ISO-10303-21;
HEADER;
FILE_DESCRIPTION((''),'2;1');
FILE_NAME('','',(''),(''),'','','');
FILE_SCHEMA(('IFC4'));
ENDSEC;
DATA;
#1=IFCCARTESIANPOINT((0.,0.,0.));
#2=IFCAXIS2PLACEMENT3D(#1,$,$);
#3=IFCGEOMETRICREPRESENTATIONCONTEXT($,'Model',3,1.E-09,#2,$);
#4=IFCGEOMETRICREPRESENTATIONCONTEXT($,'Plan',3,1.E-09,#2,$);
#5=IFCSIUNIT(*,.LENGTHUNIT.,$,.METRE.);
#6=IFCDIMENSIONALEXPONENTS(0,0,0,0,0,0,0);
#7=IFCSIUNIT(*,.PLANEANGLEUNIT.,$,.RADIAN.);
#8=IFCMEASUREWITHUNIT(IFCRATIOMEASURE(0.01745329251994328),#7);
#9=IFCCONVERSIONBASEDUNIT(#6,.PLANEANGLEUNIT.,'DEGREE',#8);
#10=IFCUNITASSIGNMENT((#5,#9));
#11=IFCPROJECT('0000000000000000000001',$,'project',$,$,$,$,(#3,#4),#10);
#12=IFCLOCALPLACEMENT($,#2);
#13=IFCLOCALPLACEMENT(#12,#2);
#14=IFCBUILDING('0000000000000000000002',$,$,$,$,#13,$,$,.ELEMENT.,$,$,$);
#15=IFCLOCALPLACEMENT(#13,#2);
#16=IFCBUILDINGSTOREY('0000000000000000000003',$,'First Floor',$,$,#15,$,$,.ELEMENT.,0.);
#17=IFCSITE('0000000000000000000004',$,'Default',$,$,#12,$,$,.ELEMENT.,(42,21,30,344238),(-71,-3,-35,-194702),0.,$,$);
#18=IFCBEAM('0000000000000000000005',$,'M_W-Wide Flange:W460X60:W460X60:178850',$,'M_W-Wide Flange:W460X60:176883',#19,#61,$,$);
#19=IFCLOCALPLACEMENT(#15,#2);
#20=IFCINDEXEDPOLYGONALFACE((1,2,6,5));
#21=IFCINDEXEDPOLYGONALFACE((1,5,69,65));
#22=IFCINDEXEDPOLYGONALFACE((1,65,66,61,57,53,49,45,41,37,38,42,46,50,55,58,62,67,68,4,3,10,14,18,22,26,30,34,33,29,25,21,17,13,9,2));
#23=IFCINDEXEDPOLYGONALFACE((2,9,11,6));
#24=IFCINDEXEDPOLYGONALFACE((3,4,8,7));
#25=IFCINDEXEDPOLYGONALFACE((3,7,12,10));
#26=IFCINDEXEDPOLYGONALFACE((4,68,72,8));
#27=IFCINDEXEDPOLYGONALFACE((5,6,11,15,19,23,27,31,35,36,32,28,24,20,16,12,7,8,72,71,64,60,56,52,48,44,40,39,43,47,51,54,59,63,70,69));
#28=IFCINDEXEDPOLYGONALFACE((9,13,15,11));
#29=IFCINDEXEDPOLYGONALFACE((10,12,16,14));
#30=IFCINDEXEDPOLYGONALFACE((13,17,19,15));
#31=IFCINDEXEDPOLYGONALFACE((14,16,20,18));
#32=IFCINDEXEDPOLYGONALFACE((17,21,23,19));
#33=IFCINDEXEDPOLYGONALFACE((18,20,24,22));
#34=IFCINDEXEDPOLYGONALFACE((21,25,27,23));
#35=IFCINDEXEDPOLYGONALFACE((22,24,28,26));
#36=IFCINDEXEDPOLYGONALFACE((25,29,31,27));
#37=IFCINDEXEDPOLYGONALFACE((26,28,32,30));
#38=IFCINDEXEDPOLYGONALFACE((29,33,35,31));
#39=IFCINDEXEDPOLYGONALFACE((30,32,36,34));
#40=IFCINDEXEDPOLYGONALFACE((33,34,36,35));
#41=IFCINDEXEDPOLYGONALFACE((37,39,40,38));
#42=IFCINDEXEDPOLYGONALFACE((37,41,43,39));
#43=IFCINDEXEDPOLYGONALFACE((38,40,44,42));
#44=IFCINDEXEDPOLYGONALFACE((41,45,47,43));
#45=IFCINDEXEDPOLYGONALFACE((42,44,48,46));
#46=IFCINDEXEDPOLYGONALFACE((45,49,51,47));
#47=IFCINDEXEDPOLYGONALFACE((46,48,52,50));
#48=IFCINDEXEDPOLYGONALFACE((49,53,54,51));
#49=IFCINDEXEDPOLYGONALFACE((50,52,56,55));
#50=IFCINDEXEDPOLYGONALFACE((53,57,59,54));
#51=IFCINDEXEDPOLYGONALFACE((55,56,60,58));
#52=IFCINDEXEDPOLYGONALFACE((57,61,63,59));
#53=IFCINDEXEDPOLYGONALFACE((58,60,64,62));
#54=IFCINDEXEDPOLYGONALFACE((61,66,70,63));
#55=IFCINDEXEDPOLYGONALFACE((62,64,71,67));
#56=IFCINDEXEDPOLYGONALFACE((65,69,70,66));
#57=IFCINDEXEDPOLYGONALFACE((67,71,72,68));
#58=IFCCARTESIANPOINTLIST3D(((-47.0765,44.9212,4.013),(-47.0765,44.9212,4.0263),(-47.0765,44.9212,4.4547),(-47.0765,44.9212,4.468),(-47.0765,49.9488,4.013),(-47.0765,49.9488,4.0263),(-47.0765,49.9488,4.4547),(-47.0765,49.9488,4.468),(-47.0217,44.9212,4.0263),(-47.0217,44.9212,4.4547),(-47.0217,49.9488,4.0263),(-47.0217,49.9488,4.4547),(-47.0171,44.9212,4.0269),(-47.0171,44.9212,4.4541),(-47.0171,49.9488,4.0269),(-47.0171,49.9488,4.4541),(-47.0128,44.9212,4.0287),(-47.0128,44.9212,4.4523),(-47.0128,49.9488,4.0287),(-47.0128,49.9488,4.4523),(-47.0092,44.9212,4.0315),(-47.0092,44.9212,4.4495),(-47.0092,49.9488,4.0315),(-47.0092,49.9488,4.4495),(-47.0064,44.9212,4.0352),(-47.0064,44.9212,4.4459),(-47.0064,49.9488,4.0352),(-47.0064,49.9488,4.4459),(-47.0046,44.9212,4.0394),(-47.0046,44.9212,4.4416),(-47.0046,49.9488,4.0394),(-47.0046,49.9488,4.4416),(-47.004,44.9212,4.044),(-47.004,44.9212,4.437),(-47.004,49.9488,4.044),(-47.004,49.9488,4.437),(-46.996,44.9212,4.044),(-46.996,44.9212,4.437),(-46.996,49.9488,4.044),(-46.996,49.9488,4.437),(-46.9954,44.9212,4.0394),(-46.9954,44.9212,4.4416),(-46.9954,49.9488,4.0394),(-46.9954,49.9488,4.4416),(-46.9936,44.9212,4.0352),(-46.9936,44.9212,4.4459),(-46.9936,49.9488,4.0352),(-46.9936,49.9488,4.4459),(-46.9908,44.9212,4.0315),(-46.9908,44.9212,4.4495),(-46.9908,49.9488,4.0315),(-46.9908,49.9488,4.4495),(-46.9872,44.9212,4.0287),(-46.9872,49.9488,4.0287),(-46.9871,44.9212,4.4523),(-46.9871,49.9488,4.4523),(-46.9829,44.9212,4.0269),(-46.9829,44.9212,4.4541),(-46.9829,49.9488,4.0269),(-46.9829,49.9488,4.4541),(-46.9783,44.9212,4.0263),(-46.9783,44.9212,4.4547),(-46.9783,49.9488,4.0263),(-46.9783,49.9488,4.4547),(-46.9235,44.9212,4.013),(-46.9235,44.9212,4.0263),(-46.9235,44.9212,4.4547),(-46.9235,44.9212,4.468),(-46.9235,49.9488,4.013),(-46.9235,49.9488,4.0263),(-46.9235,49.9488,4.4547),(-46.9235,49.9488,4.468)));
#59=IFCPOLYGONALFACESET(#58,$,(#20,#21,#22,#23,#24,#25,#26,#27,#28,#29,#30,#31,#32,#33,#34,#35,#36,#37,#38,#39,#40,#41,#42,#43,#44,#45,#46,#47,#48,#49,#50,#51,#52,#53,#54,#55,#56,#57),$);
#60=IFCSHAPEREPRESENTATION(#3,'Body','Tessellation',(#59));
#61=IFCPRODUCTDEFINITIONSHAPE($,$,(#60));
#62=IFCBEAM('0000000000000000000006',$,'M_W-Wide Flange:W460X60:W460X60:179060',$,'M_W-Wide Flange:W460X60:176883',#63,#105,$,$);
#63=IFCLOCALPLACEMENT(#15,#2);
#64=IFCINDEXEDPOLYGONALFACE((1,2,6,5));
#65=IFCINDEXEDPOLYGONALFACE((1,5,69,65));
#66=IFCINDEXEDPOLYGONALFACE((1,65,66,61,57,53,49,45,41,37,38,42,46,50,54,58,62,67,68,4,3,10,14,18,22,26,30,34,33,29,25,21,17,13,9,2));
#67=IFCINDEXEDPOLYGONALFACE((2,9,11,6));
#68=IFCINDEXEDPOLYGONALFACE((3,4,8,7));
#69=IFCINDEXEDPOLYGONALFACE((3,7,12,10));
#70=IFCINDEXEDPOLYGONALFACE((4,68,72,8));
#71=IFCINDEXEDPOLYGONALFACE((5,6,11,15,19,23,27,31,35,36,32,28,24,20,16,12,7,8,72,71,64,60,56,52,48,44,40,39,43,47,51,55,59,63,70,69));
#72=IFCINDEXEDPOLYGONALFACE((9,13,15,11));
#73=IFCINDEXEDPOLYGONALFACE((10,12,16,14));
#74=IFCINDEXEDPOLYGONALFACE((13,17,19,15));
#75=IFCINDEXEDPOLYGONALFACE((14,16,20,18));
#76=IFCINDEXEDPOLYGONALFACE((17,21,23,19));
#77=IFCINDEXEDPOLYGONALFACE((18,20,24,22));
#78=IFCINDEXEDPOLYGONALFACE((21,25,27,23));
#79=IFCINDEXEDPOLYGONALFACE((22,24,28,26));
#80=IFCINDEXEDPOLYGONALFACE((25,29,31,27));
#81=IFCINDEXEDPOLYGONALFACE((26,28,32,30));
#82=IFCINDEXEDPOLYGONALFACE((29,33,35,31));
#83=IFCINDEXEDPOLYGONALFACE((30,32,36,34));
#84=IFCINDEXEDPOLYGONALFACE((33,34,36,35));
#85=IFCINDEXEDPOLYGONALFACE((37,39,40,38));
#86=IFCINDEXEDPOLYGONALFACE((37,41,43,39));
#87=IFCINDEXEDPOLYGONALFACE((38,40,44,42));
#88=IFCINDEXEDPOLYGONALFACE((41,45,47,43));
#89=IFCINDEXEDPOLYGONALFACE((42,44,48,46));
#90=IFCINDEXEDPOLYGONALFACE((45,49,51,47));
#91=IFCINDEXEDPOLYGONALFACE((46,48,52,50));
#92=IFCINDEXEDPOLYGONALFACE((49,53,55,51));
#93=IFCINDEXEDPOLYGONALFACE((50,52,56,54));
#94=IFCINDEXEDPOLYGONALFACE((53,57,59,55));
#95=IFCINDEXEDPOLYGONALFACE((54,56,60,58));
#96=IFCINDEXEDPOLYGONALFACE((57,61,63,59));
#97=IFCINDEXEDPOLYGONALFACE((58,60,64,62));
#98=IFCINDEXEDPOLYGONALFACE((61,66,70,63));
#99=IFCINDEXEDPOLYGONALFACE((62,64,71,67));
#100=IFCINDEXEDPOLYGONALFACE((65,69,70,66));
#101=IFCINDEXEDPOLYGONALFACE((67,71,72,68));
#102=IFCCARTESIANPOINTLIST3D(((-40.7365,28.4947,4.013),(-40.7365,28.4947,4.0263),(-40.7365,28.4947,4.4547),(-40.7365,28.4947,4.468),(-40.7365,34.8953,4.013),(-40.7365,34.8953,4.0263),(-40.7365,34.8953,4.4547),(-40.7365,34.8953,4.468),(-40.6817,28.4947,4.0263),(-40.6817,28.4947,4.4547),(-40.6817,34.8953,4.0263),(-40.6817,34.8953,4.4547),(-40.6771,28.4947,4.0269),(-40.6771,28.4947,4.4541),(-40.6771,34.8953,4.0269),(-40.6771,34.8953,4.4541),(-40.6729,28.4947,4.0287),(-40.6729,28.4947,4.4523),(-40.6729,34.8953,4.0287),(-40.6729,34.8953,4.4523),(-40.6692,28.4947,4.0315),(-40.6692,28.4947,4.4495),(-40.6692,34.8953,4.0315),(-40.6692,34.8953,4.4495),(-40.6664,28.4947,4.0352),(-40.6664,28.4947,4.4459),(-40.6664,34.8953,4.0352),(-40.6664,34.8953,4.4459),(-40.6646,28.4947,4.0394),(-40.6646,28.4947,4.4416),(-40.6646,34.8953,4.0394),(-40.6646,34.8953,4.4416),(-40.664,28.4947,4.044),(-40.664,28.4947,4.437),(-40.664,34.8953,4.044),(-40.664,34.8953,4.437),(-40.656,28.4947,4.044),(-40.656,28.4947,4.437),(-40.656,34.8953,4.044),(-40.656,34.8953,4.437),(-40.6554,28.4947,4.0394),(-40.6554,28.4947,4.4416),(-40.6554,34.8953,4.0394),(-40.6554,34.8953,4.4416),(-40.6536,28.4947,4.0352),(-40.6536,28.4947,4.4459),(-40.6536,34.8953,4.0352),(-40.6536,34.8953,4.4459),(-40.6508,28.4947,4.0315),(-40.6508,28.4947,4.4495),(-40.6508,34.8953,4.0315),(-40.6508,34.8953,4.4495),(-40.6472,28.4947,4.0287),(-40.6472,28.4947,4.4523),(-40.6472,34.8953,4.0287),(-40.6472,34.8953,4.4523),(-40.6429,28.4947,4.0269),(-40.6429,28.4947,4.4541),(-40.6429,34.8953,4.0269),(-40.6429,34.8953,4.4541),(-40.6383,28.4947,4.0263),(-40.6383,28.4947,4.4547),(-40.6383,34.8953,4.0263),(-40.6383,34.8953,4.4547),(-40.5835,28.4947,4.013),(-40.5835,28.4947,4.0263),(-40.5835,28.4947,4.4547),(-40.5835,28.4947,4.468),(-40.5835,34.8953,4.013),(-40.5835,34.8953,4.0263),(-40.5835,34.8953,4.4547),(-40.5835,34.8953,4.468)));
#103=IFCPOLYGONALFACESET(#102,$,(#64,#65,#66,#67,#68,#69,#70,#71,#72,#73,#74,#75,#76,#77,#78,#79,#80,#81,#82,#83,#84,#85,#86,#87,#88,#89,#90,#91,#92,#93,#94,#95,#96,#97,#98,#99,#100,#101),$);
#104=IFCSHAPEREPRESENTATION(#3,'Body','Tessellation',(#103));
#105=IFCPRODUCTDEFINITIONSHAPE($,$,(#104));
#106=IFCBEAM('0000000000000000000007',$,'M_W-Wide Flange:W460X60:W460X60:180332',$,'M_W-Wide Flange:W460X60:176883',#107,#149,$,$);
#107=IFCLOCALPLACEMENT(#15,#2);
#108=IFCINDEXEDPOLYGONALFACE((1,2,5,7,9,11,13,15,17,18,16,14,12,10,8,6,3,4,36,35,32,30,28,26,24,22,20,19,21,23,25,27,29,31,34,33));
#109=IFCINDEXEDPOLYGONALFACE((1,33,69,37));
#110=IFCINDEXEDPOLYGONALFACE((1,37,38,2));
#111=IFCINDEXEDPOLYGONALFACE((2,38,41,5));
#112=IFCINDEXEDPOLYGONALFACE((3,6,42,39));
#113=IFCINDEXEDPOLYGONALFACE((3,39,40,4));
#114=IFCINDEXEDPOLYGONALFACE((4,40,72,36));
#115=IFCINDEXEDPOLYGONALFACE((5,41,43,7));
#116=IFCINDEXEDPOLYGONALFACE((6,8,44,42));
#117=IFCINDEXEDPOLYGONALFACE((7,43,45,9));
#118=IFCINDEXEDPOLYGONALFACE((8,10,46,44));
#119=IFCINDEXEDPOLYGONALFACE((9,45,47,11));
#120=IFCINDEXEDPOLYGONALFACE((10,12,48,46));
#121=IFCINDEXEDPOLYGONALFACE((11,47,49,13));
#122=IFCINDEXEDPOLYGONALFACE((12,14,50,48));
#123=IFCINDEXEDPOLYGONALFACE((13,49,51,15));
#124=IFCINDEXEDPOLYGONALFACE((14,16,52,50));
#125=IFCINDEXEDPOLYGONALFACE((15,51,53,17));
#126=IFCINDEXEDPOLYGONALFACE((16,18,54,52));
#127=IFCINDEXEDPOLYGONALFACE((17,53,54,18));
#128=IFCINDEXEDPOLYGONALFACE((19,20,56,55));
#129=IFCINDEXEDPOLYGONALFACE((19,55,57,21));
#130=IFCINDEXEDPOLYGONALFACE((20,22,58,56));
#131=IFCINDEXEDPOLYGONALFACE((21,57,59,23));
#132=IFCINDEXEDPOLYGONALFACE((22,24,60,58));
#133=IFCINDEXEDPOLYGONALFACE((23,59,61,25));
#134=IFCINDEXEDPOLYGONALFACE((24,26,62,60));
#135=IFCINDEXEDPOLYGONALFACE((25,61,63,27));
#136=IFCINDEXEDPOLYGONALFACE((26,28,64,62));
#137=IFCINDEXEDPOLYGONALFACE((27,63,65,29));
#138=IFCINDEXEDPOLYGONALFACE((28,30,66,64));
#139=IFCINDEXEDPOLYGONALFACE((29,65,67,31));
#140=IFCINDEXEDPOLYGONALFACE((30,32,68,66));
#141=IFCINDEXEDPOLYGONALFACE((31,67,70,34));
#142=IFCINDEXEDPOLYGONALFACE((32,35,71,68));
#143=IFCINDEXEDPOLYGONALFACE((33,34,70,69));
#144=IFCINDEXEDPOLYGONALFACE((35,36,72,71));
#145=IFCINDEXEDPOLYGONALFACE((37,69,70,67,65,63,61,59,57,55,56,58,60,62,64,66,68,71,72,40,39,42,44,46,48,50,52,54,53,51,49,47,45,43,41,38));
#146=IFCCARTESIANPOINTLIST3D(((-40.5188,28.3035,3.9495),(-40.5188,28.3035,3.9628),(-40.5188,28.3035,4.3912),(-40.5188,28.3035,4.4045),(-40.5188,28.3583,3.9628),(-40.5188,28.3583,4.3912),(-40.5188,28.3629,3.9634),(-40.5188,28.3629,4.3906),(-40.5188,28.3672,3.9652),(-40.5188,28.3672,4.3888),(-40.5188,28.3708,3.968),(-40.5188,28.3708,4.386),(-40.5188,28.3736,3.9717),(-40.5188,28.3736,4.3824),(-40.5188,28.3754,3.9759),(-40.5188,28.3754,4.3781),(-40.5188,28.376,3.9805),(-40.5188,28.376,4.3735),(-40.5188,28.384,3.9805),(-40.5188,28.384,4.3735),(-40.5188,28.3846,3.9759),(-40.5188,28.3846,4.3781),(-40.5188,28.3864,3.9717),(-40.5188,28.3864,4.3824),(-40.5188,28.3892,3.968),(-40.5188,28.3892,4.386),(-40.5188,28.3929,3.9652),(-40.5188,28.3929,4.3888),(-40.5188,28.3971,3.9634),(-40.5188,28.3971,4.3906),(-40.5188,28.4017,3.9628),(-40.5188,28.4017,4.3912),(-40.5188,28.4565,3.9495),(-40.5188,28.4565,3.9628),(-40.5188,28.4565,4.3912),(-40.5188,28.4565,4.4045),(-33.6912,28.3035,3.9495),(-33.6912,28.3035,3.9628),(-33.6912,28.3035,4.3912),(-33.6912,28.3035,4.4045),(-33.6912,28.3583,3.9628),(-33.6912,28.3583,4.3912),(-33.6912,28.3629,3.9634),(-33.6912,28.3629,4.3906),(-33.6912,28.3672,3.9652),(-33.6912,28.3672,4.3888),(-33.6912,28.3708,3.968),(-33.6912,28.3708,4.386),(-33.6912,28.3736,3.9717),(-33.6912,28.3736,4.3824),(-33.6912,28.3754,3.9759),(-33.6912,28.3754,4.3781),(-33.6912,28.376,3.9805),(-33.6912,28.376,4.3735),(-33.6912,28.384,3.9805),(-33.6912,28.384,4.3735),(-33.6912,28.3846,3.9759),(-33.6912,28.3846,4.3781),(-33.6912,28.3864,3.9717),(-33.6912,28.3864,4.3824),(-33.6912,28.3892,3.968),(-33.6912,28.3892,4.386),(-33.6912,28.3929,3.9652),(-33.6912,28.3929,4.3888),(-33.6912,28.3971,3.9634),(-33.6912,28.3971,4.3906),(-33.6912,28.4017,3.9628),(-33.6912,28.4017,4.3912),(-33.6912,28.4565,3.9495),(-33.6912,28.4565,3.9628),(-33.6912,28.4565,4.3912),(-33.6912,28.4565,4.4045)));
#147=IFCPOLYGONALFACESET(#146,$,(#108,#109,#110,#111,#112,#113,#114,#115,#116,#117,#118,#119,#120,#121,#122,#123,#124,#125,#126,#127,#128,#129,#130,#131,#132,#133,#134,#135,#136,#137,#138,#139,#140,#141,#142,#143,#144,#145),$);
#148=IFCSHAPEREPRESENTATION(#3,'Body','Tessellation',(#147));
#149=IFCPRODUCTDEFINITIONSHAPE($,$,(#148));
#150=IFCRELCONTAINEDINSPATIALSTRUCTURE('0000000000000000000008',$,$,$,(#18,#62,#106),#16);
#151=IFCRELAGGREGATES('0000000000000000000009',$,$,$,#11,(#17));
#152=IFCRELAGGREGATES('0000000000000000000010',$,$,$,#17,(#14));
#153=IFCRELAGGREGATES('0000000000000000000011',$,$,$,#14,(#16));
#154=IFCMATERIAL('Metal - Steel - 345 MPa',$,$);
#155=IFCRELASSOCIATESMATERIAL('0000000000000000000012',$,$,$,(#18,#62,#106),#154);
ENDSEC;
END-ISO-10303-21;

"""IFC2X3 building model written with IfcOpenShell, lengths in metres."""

from ifc_helpers import new_model, entity, si_unit, converted_unit, frame, frame_2d, origin, place, context, project, spatial, polyline, circle_curve, parameter, trimmed, segment, composite_curve, outline, extrude, material, element, save


model = new_model("IFC2X3")

# Units and contexts
model_context = context("Model", 3, precision=1e-09, world=origin())
plan_context = context("Plan", 3, precision=1e-09, world=origin())
ifc_project = project(units=[si_unit("LENGTHUNIT", "METRE"), converted_unit("PLANEANGLEUNIT", "DEGREE", entity("IfcRatioMeasure", 0.01745329251994328), si_unit("PLANEANGLEUNIT", "RADIAN"), dimensions=[0, 0, 0, 0, 0, 0, 0])], contexts=[model_context, plan_context])

# Site, building, storey
site_placement = place(None, origin())
site = spatial("IfcSite", under=ifc_project, at=site_placement, Name="Default", CompositionType="ELEMENT", RefLatitude=(42, 21, 30, 344238), RefLongitude=(-71, -3, -35, -194702), RefElevation=0.0)
building_placement = place(site_placement, origin())
building = spatial("IfcBuilding", under=site, at=building_placement, CompositionType="ELEMENT")
storey_placement = place(building_placement, origin())
storey = spatial("IfcBuildingStorey", under=building, at=storey_placement, Name="First Floor", CompositionType="ELEMENT", Elevation=0.0)

# Beams
ifc_material = material(Name="Metal - Steel - 345 MPa")
beam_1_placement = place(storey_placement, frame((-47.0, 44.7774, 4.468)))
element("IfcBeam", 1, at=beam_1_placement, inside=storey, material=ifc_material, Name="M_W-Wide Flange:W460X60:W460X60:178850", ObjectType="M_W-Wide Flange:W460X60:176883", context=model_context, shape_type="SweptSolid", body=[
    extrude(outline(composite_curve([segment(polyline([(-0.0765, -0.2142), (-0.0765, -0.2275)]), True, "CONTINUOUS"), segment(polyline([(-0.0765, -0.2275), (0.0765, -0.2275)]), True, "CONTINUOUS"), segment(polyline([(0.0765, -0.2275), (0.0765, -0.2142)]), True, "CONTINUOUS"), segment(polyline([(0.0765, -0.2142), (0.0217, -0.2142)]), True, "CONTINUOUS"), segment(trimmed(circle_curve(frame_2d((0.0217, -0.1965), x_axis=(0.0, -1.0)), 0.0177), [parameter(270.0)], [parameter(360.0)], True, "PARAMETER"), False, "CONTINUOUS"), segment(polyline([(0.004, -0.1965), (0.004, 0.1965)]), True, "CONTINUOUS"), segment(trimmed(circle_curve(frame_2d((0.0217, 0.1965), x_axis=(-1.0, 0.0)), 0.0177), [parameter(270.0)], [parameter(360.0)], True, "PARAMETER"), False, "CONTINUOUS"), segment(polyline([(0.0217, 0.2142), (0.0765, 0.2142)]), True, "CONTINUOUS"), segment(polyline([(0.0765, 0.2142), (0.0765, 0.2275)]), True, "CONTINUOUS"), segment(polyline([(0.0765, 0.2275), (-0.0765, 0.2275)]), True, "CONTINUOUS"), segment(polyline([(-0.0765, 0.2275), (-0.0765, 0.2142)]), True, "CONTINUOUS"), segment(polyline([(-0.0765, 0.2142), (-0.0217, 0.2142)]), True, "CONTINUOUS"), segment(trimmed(circle_curve(frame_2d((-0.0217, 0.1965), x_axis=(0.0, 1.0)), 0.0177), [parameter(270.0)], [parameter(360.0)], True, "PARAMETER"), False, "CONTINUOUS"), segment(polyline([(-0.004, 0.1965), (-0.004, -0.1965)]), True, "CONTINUOUS"), segment(trimmed(circle_curve(frame_2d((-0.0217, -0.1965), x_axis=(1.0, 0.0)), 0.0177), [parameter(270.0)], [parameter(0.0)], True, "PARAMETER"), False, "CONTINUOUS"), segment(polyline([(-0.0217, -0.2142), (-0.0765, -0.2142)]), True, "CONTINUOUS")], self_intersect=False)), frame((0.0, 0.1438, -0.2275), z_axis=(0.0, -1.0, 0.0), x_axis=(1.0, 0.0, 0.0)), (0.0, 0.0, -1.0), 5.0276),
])
beam_2_placement = place(storey_placement, frame((-40.66, 35.0121, 4.468), z_axis=(0.0, 0.0, 1.0), x_axis=(-1.0, 0.0, 0.0)))
element("IfcBeam", 2, at=beam_2_placement, inside=storey, material=ifc_material, Name="M_W-Wide Flange:W460X60:W460X60:179060", ObjectType="M_W-Wide Flange:W460X60:176883", context=model_context, shape_type="SweptSolid", body=[
    extrude(outline(composite_curve([segment(polyline([(0.2142, -0.0765), (0.2275, -0.0765)]), True, "CONTINUOUS"), segment(polyline([(0.2275, -0.0765), (0.2275, 0.0765)]), True, "CONTINUOUS"), segment(polyline([(0.2275, 0.0765), (0.2142, 0.0765)]), True, "CONTINUOUS"), segment(polyline([(0.2142, 0.0765), (0.2142, 0.0217)]), True, "CONTINUOUS"), segment(trimmed(circle_curve(frame_2d((0.1965, 0.0217), x_axis=(1.0, 0.0)), 0.0177), [parameter(270.0)], [parameter(360.0)], True, "PARAMETER"), False, "CONTINUOUS"), segment(polyline([(0.1965, 0.004), (-0.1965, 0.004)]), True, "CONTINUOUS"), segment(trimmed(circle_curve(frame_2d((-0.1965, 0.0217), x_axis=(0.0, -1.0)), 0.0177), [parameter(270.0)], [parameter(360.0)], True, "PARAMETER"), False, "CONTINUOUS"), segment(polyline([(-0.2142, 0.0217), (-0.2142, 0.0765)]), True, "CONTINUOUS"), segment(polyline([(-0.2142, 0.0765), (-0.2275, 0.0765)]), True, "CONTINUOUS"), segment(polyline([(-0.2275, 0.0765), (-0.2275, -0.0765)]), True, "CONTINUOUS"), segment(polyline([(-0.2275, -0.0765), (-0.2142, -0.0765)]), True, "CONTINUOUS"), segment(polyline([(-0.2142, -0.0765), (-0.2142, -0.0217)]), True, "CONTINUOUS"), segment(trimmed(circle_curve(frame_2d((-0.1965, -0.0217), x_axis=(-1.0, 0.0)), 0.0177), [parameter(270.0)], [parameter(360.0)], True, "PARAMETER"), False, "CONTINUOUS"), segment(polyline([(-0.1965, -0.004), (0.1965, -0.004)]), True, "CONTINUOUS"), segment(trimmed(circle_curve(frame_2d((0.1965, -0.0217), x_axis=(0.0, 1.0)), 0.0177), [parameter(270.0)], [parameter(0.0)], True, "PARAMETER"), False, "CONTINUOUS"), segment(polyline([(0.2142, -0.0217), (0.2142, -0.0765)]), True, "CONTINUOUS")], self_intersect=False)), frame((0.0, 6.5174, -0.2275), z_axis=(0.0, -1.0, 0.0), x_axis=(0.0, 0.0, -1.0)), (0.0, 0.0, 1.0), 6.4006),
])
beam_3_placement = place(storey_placement, frame((-33.5481, 28.38, 4.4045), z_axis=(0.0, 0.0, 1.0), x_axis=(0.0, 1.0, 0.0)))
element("IfcBeam", 3, at=beam_3_placement, inside=storey, material=ifc_material, Name="M_W-Wide Flange:W460X60:W460X60:180332", ObjectType="M_W-Wide Flange:W460X60:176883", context=model_context, shape_type="SweptSolid", body=[
    extrude(outline(composite_curve([segment(polyline([(0.2142, -0.0765), (0.2275, -0.0765)]), True, "CONTINUOUS"), segment(polyline([(0.2275, -0.0765), (0.2275, 0.0765)]), True, "CONTINUOUS"), segment(polyline([(0.2275, 0.0765), (0.2142, 0.0765)]), True, "CONTINUOUS"), segment(polyline([(0.2142, 0.0765), (0.2142, 0.0217)]), True, "CONTINUOUS"), segment(trimmed(circle_curve(frame_2d((0.1965, 0.0217), x_axis=(1.0, 0.0)), 0.0177), [parameter(270.0)], [parameter(360.0)], True, "PARAMETER"), False, "CONTINUOUS"), segment(polyline([(0.1965, 0.004), (-0.1965, 0.004)]), True, "CONTINUOUS"), segment(trimmed(circle_curve(frame_2d((-0.1965, 0.0217), x_axis=(0.0, -1.0)), 0.0177), [parameter(270.0)], [parameter(360.0)], True, "PARAMETER"), False, "CONTINUOUS"), segment(polyline([(-0.2142, 0.0217), (-0.2142, 0.0765)]), True, "CONTINUOUS"), segment(polyline([(-0.2142, 0.0765), (-0.2275, 0.0765)]), True, "CONTINUOUS"), segment(polyline([(-0.2275, 0.0765), (-0.2275, -0.0765)]), True, "CONTINUOUS"), segment(polyline([(-0.2275, -0.0765), (-0.2142, -0.0765)]), True, "CONTINUOUS"), segment(polyline([(-0.2142, -0.0765), (-0.2142, -0.0217)]), True, "CONTINUOUS"), segment(trimmed(circle_curve(frame_2d((-0.1965, -0.0217), x_axis=(-1.0, 0.0)), 0.0177), [parameter(270.0)], [parameter(360.0)], True, "PARAMETER"), False, "CONTINUOUS"), segment(polyline([(-0.1965, -0.004), (0.1965, -0.004)]), True, "CONTINUOUS"), segment(trimmed(circle_curve(frame_2d((0.1965, -0.0217), x_axis=(0.0, 1.0)), 0.0177), [parameter(270.0)], [parameter(0.0)], True, "PARAMETER"), False, "CONTINUOUS"), segment(polyline([(0.2142, -0.0217), (0.2142, -0.0765)]), True, "CONTINUOUS")], self_intersect=False)), frame((0.0, 6.9707, -0.2275), z_axis=(0.0, -1.0, 0.0), x_axis=(0.0, 0.0, -1.0)), (0.0, 0.0, 1.0), 6.8276),
])

save(model, "model.ifc")
